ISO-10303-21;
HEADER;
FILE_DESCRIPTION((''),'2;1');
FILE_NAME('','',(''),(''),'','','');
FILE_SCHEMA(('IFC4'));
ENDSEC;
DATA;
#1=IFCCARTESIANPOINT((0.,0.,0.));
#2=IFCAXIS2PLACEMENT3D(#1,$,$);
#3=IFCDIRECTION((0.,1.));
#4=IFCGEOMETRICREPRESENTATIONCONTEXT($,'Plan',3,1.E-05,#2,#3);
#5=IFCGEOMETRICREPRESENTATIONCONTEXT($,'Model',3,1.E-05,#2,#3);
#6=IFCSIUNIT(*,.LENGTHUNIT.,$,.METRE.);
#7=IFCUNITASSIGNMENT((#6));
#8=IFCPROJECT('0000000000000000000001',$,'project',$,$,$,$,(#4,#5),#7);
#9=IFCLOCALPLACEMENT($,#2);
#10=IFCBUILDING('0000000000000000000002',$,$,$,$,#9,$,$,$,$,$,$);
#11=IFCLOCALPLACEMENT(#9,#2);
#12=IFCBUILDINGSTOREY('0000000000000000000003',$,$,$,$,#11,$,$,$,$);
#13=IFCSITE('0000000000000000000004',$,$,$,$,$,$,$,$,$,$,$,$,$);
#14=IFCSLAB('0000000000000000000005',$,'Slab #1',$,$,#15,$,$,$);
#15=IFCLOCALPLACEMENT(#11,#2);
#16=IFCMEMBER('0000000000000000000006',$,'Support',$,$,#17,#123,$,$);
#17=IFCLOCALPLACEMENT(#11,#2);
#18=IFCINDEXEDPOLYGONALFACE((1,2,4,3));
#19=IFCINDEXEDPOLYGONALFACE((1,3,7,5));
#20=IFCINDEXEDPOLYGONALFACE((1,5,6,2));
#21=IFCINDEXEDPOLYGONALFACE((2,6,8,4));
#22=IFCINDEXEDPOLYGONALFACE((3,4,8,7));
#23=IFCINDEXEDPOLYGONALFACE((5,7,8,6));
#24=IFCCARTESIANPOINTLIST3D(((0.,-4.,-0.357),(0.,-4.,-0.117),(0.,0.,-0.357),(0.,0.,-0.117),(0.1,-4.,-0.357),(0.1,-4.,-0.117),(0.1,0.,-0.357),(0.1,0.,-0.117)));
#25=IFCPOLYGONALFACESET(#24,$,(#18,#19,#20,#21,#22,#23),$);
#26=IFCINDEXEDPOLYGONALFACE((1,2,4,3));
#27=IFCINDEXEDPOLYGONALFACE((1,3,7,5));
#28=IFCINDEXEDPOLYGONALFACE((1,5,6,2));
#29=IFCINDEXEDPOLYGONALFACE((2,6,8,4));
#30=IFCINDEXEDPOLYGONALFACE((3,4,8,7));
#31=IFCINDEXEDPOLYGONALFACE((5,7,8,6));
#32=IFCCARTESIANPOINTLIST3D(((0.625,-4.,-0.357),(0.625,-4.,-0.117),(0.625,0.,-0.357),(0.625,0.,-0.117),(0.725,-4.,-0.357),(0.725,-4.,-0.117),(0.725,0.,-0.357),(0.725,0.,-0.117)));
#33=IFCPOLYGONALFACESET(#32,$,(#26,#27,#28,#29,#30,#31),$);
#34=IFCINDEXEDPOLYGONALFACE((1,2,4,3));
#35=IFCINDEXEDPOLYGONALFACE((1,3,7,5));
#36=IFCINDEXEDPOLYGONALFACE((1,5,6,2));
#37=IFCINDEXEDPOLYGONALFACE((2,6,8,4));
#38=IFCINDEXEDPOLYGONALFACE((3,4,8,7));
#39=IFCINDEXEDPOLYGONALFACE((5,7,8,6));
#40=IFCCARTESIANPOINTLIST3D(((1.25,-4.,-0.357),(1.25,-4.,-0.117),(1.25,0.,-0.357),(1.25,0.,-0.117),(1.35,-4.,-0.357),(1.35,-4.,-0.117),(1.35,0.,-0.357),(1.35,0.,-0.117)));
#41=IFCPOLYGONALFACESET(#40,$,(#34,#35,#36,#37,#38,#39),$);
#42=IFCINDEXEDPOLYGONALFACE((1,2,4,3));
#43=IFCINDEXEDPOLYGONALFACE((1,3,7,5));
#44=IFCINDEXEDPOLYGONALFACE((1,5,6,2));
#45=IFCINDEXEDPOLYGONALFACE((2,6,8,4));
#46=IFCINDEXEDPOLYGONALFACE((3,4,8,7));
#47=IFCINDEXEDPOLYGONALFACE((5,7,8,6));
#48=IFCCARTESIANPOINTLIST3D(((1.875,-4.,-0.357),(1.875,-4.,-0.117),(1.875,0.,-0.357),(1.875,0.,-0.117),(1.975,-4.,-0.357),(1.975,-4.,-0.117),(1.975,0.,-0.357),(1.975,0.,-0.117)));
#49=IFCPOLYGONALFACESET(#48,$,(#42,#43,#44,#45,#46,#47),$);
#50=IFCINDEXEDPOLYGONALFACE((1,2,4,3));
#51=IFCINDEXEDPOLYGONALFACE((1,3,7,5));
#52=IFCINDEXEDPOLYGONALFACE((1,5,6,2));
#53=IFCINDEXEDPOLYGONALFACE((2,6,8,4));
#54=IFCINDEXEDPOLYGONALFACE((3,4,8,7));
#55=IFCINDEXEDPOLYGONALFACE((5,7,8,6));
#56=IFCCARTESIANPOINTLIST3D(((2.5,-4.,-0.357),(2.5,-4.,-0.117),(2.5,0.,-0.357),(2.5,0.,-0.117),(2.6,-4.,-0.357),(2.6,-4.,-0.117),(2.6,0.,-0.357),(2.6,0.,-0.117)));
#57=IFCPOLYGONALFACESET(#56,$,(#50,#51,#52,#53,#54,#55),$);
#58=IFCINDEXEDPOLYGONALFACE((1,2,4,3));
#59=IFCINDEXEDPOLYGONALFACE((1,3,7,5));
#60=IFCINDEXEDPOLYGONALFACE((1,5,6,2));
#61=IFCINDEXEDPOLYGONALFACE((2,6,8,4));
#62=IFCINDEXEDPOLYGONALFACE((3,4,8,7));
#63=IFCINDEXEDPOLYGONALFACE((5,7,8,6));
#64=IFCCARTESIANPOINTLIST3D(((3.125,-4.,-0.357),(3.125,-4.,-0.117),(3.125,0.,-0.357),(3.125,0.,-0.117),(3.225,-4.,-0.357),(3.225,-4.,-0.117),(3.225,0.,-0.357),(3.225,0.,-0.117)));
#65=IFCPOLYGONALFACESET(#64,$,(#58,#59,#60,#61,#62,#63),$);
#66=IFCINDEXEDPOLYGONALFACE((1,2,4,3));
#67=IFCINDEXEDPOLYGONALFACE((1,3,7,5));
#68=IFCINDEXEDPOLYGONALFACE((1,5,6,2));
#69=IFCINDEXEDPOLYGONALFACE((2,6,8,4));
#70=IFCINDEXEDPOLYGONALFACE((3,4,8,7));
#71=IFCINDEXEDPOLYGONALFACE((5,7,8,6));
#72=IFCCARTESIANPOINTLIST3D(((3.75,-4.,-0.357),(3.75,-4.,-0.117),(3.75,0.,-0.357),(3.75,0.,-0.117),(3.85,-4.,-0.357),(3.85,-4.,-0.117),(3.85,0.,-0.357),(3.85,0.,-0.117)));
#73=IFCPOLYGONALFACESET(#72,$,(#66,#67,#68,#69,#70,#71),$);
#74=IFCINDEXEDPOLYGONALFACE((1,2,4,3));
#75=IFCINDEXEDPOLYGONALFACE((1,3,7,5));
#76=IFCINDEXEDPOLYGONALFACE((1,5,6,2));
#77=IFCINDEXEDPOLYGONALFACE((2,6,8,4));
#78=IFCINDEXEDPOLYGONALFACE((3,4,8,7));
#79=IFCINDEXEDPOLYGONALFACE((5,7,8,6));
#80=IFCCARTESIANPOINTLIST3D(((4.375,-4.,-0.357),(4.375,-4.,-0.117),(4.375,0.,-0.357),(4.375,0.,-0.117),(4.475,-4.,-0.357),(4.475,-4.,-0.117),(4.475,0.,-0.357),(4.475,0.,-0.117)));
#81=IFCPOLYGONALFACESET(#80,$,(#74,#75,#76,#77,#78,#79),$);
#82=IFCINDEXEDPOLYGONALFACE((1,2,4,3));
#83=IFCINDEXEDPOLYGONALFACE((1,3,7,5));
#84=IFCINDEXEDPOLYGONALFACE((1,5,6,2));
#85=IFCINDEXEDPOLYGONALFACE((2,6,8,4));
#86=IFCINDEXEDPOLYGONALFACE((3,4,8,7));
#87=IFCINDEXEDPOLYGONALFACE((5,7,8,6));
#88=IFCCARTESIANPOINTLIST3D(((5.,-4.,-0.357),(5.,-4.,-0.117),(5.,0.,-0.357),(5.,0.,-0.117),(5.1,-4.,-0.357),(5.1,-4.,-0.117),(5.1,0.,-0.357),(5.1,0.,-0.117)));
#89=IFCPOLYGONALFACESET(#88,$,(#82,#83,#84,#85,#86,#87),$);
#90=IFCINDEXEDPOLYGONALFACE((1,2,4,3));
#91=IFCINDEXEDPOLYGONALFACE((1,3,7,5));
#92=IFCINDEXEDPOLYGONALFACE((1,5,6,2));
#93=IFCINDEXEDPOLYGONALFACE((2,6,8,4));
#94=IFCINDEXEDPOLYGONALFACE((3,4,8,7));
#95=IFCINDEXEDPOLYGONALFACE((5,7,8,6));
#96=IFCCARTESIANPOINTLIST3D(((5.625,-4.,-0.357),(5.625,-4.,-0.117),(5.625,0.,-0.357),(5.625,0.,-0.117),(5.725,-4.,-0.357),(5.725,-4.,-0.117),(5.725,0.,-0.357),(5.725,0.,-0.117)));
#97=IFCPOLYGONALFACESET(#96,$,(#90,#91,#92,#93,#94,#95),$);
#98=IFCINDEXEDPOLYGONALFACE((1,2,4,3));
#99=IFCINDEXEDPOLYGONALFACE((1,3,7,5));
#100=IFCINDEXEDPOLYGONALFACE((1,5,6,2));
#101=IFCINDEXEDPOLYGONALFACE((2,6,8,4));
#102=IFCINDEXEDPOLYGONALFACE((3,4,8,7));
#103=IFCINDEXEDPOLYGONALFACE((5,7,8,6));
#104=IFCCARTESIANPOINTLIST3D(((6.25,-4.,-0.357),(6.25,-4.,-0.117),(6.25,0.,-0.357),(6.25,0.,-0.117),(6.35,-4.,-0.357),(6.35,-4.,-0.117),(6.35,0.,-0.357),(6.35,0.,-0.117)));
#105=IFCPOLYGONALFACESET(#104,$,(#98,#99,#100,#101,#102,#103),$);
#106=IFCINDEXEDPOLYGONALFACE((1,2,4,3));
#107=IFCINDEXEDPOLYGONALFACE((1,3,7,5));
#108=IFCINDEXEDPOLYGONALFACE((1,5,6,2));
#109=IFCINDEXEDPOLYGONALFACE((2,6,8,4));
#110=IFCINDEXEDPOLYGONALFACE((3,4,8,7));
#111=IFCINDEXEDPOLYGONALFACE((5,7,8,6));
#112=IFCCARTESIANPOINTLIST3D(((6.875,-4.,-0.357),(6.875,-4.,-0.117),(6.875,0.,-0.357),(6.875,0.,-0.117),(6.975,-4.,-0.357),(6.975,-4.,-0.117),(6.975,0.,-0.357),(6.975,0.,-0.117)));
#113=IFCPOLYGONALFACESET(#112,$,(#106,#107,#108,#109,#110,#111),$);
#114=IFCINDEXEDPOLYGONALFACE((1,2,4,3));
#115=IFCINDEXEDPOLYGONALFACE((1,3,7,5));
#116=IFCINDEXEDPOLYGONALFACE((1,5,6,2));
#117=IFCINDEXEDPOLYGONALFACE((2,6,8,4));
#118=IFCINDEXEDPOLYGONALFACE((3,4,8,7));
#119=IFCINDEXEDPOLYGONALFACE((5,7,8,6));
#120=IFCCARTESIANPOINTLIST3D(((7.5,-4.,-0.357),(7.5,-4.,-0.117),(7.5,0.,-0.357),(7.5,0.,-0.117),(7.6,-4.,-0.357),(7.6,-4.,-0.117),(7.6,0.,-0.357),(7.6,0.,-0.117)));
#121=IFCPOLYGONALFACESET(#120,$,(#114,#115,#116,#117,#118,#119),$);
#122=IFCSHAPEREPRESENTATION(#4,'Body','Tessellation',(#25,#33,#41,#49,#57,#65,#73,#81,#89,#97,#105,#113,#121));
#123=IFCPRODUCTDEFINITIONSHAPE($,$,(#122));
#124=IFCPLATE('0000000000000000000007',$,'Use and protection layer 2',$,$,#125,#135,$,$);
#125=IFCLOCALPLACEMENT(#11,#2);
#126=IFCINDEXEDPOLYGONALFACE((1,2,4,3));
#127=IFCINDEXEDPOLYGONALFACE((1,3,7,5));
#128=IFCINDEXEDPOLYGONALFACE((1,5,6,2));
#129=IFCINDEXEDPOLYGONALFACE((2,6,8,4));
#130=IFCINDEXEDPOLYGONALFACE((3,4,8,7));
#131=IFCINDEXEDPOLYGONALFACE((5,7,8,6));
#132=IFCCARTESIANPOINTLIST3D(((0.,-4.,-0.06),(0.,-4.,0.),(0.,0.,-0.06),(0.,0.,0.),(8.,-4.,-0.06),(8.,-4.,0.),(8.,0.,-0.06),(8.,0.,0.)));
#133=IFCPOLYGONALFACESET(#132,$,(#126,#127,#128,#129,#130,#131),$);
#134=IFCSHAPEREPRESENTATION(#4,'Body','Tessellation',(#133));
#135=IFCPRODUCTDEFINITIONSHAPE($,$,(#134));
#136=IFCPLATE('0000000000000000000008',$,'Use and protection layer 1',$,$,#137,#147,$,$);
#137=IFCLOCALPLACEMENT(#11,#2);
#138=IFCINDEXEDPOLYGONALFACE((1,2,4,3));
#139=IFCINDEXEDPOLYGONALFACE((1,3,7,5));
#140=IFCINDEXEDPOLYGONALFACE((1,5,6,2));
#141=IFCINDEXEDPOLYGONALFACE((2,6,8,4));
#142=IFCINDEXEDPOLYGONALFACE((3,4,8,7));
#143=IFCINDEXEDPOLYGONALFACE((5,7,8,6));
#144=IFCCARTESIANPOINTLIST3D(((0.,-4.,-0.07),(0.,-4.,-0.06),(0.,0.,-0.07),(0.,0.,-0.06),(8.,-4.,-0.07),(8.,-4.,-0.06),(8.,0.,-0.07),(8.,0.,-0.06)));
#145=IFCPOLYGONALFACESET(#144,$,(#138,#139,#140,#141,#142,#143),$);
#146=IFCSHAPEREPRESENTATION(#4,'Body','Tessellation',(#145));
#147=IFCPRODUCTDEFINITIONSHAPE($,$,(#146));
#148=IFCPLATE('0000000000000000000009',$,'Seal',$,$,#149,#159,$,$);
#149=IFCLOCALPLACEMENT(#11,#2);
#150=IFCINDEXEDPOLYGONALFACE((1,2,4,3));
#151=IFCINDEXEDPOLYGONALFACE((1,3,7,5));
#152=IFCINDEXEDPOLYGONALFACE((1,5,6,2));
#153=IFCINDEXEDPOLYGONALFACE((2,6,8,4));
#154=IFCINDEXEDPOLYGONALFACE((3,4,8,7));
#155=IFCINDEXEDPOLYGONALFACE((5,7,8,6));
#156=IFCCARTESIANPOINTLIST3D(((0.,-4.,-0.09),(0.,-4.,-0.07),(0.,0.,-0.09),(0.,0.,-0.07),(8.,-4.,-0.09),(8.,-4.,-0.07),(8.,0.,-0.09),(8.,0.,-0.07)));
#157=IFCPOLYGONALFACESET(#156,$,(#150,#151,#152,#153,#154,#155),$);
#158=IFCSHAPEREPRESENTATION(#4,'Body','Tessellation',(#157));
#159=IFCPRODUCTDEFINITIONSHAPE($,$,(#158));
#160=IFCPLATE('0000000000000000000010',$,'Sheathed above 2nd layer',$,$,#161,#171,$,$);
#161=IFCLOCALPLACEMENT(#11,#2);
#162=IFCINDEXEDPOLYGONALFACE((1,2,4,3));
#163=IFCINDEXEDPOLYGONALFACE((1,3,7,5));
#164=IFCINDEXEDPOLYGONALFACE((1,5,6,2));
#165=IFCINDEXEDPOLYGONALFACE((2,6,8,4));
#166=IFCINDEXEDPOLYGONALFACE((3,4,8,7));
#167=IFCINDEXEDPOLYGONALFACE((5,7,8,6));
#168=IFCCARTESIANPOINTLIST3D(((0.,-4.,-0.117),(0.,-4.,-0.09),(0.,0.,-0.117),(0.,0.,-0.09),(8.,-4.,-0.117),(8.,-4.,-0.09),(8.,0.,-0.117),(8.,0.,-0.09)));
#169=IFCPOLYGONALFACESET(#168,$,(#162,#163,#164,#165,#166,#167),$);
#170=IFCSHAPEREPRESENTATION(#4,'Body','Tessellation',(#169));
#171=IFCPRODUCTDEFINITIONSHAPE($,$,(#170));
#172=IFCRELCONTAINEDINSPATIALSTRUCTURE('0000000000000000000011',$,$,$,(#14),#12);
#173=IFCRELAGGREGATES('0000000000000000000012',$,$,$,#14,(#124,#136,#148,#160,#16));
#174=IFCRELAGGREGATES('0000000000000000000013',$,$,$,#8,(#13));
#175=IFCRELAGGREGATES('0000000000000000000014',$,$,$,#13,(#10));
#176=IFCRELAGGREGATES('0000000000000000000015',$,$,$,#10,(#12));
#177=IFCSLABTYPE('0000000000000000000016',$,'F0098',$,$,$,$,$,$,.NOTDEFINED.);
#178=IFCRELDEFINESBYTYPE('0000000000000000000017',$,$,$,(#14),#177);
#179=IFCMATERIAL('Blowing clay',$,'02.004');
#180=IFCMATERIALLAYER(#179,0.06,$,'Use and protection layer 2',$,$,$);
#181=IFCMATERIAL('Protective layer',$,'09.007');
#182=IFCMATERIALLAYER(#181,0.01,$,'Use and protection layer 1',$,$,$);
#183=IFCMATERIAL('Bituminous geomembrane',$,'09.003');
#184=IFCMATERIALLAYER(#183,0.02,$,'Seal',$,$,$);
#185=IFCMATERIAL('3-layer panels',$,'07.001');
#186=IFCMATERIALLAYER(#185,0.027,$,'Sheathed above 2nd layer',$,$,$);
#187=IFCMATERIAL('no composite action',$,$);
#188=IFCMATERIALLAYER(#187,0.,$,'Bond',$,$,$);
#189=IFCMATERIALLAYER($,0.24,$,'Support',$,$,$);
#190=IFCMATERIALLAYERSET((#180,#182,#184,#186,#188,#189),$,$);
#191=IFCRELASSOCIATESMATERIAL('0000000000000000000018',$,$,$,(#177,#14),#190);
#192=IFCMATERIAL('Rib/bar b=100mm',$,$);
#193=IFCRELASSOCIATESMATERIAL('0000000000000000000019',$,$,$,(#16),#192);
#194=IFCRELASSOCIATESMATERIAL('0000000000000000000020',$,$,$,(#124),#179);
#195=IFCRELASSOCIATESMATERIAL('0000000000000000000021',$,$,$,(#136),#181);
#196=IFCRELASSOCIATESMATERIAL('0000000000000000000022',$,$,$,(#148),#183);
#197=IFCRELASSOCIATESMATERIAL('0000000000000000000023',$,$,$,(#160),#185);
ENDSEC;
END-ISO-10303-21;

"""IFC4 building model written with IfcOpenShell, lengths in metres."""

from ifc_helpers import new_model, si_unit, direction, frame, frame_2d, origin, origin_with_axes, place, context, project, spatial, rectangle, extrude, material, layer, layer_set, type_object, element, aggregate, save


model = new_model("IFC4")

# Units and contexts
plan_context = context("Plan", 3, precision=1e-05, world=origin(), true_north=direction((0.0, 1.0)))
model_context = context("Model", 3, precision=1e-05, world=origin(), true_north=direction((0.0, 1.0)))
ifc_project = project(units=[si_unit("LENGTHUNIT", "METRE")], contexts=[plan_context, model_context])

# Site, building, storey
site = spatial("IfcSite", under=ifc_project)
building_placement = place(None, origin())
building = spatial("IfcBuilding", under=site, at=building_placement)
storey_placement = place(building_placement, origin())
storey = spatial("IfcBuildingStorey", under=building, at=storey_placement)

# Slab, member, plates
ifc_material_1 = material(Name="Blowing clay", Category="02.004")
ifc_layer_1 = layer(ifc_material_1, 0.06, Name="Use and protection layer 2")
ifc_material_2 = material(Name="Protective layer", Category="09.007")
ifc_layer_2 = layer(ifc_material_2, 0.01, Name="Use and protection layer 1")
ifc_material_3 = material(Name="Bituminous geomembrane", Category="09.003")
ifc_layer_3 = layer(ifc_material_3, 0.02, Name="Seal")
ifc_material_4 = material(Name="3-layer panels", Category="07.001")
ifc_layer_4 = layer(ifc_material_4, 0.027, Name="Sheathed above 2nd layer")
ifc_material_5 = material(Name="no composite action")
ifc_layer_5 = layer(ifc_material_5, 0.0, Name="Bond")
ifc_layer_6 = layer(None, 0.24, Name="Support")
ifc_layer_set = layer_set([ifc_layer_1, ifc_layer_2, ifc_layer_3, ifc_layer_4, ifc_layer_5, ifc_layer_6])
slab_type = type_object("IfcSlabType", Name="F0098", PredefinedType="NOTDEFINED", material=ifc_layer_set)
slab_placement = place(None, frame((0.0, 0.0, 0.0), z_axis=(0.0, 0.0, -1.0), x_axis=(1.0, 0.0, 0.0)))
slab = element("IfcSlab", 1, at=slab_placement, inside=storey, type_object=slab_type, material=ifc_layer_set, Name="Slab #1")
ifc_material_6 = material(Name="Rib/bar b=100mm")
member_placement = place(slab_placement, origin())
member = element("IfcMember", 2, at=member_placement, material=ifc_material_6, Name="Support", context=plan_context, shape_type="SweptSolid", body=[
    extrude(rectangle(XDim=0.1, YDim=0.24, at=frame_2d((0.05, 0.12), x_axis=(1.0, 0.0))), frame((0.0, 4.0, 0.117), z_axis=(0.0, -1.0, 0.0), x_axis=(1.0, 0.0, 0.0)), (0.0, 0.0, 1.0), 4.0),
    extrude(rectangle(XDim=0.1, YDim=0.24, at=frame_2d((0.05, 0.12), x_axis=(1.0, 0.0))), frame((0.625, 4.0, 0.117), z_axis=(0.0, -1.0, 0.0), x_axis=(1.0, 0.0, 0.0)), (0.0, 0.0, 1.0), 4.0),
    extrude(rectangle(XDim=0.1, YDim=0.24, at=frame_2d((0.05, 0.12), x_axis=(1.0, 0.0))), frame((1.25, 4.0, 0.117), z_axis=(0.0, -1.0, 0.0), x_axis=(1.0, 0.0, 0.0)), (0.0, 0.0, 1.0), 4.0),
    extrude(rectangle(XDim=0.1, YDim=0.24, at=frame_2d((0.05, 0.12), x_axis=(1.0, 0.0))), frame((1.875, 4.0, 0.117), z_axis=(0.0, -1.0, 0.0), x_axis=(1.0, 0.0, 0.0)), (0.0, 0.0, 1.0), 4.0),
    extrude(rectangle(XDim=0.1, YDim=0.24, at=frame_2d((0.05, 0.12), x_axis=(1.0, 0.0))), frame((2.5, 4.0, 0.117), z_axis=(0.0, -1.0, 0.0), x_axis=(1.0, 0.0, 0.0)), (0.0, 0.0, 1.0), 4.0),
    extrude(rectangle(XDim=0.1, YDim=0.24, at=frame_2d((0.05, 0.12), x_axis=(1.0, 0.0))), frame((3.125, 4.0, 0.117), z_axis=(0.0, -1.0, 0.0), x_axis=(1.0, 0.0, 0.0)), (0.0, 0.0, 1.0), 4.0),
    extrude(rectangle(XDim=0.1, YDim=0.24, at=frame_2d((0.05, 0.12), x_axis=(1.0, 0.0))), frame((3.75, 4.0, 0.117), z_axis=(0.0, -1.0, 0.0), x_axis=(1.0, 0.0, 0.0)), (0.0, 0.0, 1.0), 4.0),
    extrude(rectangle(XDim=0.1, YDim=0.24, at=frame_2d((0.05, 0.12), x_axis=(1.0, 0.0))), frame((4.375, 4.0, 0.117), z_axis=(0.0, -1.0, 0.0), x_axis=(1.0, 0.0, 0.0)), (0.0, 0.0, 1.0), 4.0),
    extrude(rectangle(XDim=0.1, YDim=0.24, at=frame_2d((0.05, 0.12), x_axis=(1.0, 0.0))), frame((5.0, 4.0, 0.117), z_axis=(0.0, -1.0, 0.0), x_axis=(1.0, 0.0, 0.0)), (0.0, 0.0, 1.0), 4.0),
    extrude(rectangle(XDim=0.1, YDim=0.24, at=frame_2d((0.05, 0.12), x_axis=(1.0, 0.0))), frame((5.625, 4.0, 0.117), z_axis=(0.0, -1.0, 0.0), x_axis=(1.0, 0.0, 0.0)), (0.0, 0.0, 1.0), 4.0),
    extrude(rectangle(XDim=0.1, YDim=0.24, at=frame_2d((0.05, 0.12), x_axis=(1.0, 0.0))), frame((6.25, 4.0, 0.117), z_axis=(0.0, -1.0, 0.0), x_axis=(1.0, 0.0, 0.0)), (0.0, 0.0, 1.0), 4.0),
    extrude(rectangle(XDim=0.1, YDim=0.24, at=frame_2d((0.05, 0.12), x_axis=(1.0, 0.0))), frame((6.875, 4.0, 0.117), z_axis=(0.0, -1.0, 0.0), x_axis=(1.0, 0.0, 0.0)), (0.0, 0.0, 1.0), 4.0),
    extrude(rectangle(XDim=0.1, YDim=0.24, at=frame_2d((0.05, 0.12), x_axis=(1.0, 0.0))), frame((7.5, 4.0, 0.117), z_axis=(0.0, -1.0, 0.0), x_axis=(1.0, 0.0, 0.0)), (0.0, 0.0, 1.0), 4.0),
])
plate_1_placement = place(slab_placement, origin())
plate_1 = element("IfcPlate", 3, at=plate_1_placement, material=ifc_material_1, Name="Use and protection layer 2", context=plan_context, shape_type="SweptSolid", body=[
    extrude(rectangle(XDim=8.0, YDim=4.0, at=frame_2d((4.0, 2.0), x_axis=(1.0, 0.0))), origin_with_axes(), (0.0, 0.0, 1.0), 0.06),
])
plate_2_placement = place(slab_placement, origin())
plate_2 = element("IfcPlate", 4, at=plate_2_placement, material=ifc_material_2, Name="Use and protection layer 1", context=plan_context, shape_type="SweptSolid", body=[
    extrude(rectangle(XDim=8.0, YDim=4.0, at=frame_2d((4.0, 2.0), x_axis=(1.0, 0.0))), frame((0.0, 0.0, 0.06), z_axis=(0.0, 0.0, 1.0), x_axis=(1.0, 0.0, 0.0)), (0.0, 0.0, 1.0), 0.01),
])
plate_3_placement = place(slab_placement, origin())
plate_3 = element("IfcPlate", 5, at=plate_3_placement, material=ifc_material_3, Name="Seal", context=plan_context, shape_type="SweptSolid", body=[
    extrude(rectangle(XDim=8.0, YDim=4.0, at=frame_2d((4.0, 2.0), x_axis=(1.0, 0.0))), frame((0.0, 0.0, 0.07), z_axis=(0.0, 0.0, 1.0), x_axis=(1.0, 0.0, 0.0)), (0.0, 0.0, 1.0), 0.02),
])
plate_4_placement = place(slab_placement, origin())
plate_4 = element("IfcPlate", 6, at=plate_4_placement, material=ifc_material_4, Name="Sheathed above 2nd layer", context=plan_context, shape_type="SweptSolid", body=[
    extrude(rectangle(XDim=8.0, YDim=4.0, at=frame_2d((4.0, 2.0), x_axis=(1.0, 0.0))), frame((0.0, 0.0, 0.09), z_axis=(0.0, 0.0, 1.0), x_axis=(1.0, 0.0, 0.0)), (0.0, 0.0, 1.0), 0.027),
])
aggregate(slab, [plate_1, plate_2, plate_3, plate_4, member])

save(model, "model.ifc")
